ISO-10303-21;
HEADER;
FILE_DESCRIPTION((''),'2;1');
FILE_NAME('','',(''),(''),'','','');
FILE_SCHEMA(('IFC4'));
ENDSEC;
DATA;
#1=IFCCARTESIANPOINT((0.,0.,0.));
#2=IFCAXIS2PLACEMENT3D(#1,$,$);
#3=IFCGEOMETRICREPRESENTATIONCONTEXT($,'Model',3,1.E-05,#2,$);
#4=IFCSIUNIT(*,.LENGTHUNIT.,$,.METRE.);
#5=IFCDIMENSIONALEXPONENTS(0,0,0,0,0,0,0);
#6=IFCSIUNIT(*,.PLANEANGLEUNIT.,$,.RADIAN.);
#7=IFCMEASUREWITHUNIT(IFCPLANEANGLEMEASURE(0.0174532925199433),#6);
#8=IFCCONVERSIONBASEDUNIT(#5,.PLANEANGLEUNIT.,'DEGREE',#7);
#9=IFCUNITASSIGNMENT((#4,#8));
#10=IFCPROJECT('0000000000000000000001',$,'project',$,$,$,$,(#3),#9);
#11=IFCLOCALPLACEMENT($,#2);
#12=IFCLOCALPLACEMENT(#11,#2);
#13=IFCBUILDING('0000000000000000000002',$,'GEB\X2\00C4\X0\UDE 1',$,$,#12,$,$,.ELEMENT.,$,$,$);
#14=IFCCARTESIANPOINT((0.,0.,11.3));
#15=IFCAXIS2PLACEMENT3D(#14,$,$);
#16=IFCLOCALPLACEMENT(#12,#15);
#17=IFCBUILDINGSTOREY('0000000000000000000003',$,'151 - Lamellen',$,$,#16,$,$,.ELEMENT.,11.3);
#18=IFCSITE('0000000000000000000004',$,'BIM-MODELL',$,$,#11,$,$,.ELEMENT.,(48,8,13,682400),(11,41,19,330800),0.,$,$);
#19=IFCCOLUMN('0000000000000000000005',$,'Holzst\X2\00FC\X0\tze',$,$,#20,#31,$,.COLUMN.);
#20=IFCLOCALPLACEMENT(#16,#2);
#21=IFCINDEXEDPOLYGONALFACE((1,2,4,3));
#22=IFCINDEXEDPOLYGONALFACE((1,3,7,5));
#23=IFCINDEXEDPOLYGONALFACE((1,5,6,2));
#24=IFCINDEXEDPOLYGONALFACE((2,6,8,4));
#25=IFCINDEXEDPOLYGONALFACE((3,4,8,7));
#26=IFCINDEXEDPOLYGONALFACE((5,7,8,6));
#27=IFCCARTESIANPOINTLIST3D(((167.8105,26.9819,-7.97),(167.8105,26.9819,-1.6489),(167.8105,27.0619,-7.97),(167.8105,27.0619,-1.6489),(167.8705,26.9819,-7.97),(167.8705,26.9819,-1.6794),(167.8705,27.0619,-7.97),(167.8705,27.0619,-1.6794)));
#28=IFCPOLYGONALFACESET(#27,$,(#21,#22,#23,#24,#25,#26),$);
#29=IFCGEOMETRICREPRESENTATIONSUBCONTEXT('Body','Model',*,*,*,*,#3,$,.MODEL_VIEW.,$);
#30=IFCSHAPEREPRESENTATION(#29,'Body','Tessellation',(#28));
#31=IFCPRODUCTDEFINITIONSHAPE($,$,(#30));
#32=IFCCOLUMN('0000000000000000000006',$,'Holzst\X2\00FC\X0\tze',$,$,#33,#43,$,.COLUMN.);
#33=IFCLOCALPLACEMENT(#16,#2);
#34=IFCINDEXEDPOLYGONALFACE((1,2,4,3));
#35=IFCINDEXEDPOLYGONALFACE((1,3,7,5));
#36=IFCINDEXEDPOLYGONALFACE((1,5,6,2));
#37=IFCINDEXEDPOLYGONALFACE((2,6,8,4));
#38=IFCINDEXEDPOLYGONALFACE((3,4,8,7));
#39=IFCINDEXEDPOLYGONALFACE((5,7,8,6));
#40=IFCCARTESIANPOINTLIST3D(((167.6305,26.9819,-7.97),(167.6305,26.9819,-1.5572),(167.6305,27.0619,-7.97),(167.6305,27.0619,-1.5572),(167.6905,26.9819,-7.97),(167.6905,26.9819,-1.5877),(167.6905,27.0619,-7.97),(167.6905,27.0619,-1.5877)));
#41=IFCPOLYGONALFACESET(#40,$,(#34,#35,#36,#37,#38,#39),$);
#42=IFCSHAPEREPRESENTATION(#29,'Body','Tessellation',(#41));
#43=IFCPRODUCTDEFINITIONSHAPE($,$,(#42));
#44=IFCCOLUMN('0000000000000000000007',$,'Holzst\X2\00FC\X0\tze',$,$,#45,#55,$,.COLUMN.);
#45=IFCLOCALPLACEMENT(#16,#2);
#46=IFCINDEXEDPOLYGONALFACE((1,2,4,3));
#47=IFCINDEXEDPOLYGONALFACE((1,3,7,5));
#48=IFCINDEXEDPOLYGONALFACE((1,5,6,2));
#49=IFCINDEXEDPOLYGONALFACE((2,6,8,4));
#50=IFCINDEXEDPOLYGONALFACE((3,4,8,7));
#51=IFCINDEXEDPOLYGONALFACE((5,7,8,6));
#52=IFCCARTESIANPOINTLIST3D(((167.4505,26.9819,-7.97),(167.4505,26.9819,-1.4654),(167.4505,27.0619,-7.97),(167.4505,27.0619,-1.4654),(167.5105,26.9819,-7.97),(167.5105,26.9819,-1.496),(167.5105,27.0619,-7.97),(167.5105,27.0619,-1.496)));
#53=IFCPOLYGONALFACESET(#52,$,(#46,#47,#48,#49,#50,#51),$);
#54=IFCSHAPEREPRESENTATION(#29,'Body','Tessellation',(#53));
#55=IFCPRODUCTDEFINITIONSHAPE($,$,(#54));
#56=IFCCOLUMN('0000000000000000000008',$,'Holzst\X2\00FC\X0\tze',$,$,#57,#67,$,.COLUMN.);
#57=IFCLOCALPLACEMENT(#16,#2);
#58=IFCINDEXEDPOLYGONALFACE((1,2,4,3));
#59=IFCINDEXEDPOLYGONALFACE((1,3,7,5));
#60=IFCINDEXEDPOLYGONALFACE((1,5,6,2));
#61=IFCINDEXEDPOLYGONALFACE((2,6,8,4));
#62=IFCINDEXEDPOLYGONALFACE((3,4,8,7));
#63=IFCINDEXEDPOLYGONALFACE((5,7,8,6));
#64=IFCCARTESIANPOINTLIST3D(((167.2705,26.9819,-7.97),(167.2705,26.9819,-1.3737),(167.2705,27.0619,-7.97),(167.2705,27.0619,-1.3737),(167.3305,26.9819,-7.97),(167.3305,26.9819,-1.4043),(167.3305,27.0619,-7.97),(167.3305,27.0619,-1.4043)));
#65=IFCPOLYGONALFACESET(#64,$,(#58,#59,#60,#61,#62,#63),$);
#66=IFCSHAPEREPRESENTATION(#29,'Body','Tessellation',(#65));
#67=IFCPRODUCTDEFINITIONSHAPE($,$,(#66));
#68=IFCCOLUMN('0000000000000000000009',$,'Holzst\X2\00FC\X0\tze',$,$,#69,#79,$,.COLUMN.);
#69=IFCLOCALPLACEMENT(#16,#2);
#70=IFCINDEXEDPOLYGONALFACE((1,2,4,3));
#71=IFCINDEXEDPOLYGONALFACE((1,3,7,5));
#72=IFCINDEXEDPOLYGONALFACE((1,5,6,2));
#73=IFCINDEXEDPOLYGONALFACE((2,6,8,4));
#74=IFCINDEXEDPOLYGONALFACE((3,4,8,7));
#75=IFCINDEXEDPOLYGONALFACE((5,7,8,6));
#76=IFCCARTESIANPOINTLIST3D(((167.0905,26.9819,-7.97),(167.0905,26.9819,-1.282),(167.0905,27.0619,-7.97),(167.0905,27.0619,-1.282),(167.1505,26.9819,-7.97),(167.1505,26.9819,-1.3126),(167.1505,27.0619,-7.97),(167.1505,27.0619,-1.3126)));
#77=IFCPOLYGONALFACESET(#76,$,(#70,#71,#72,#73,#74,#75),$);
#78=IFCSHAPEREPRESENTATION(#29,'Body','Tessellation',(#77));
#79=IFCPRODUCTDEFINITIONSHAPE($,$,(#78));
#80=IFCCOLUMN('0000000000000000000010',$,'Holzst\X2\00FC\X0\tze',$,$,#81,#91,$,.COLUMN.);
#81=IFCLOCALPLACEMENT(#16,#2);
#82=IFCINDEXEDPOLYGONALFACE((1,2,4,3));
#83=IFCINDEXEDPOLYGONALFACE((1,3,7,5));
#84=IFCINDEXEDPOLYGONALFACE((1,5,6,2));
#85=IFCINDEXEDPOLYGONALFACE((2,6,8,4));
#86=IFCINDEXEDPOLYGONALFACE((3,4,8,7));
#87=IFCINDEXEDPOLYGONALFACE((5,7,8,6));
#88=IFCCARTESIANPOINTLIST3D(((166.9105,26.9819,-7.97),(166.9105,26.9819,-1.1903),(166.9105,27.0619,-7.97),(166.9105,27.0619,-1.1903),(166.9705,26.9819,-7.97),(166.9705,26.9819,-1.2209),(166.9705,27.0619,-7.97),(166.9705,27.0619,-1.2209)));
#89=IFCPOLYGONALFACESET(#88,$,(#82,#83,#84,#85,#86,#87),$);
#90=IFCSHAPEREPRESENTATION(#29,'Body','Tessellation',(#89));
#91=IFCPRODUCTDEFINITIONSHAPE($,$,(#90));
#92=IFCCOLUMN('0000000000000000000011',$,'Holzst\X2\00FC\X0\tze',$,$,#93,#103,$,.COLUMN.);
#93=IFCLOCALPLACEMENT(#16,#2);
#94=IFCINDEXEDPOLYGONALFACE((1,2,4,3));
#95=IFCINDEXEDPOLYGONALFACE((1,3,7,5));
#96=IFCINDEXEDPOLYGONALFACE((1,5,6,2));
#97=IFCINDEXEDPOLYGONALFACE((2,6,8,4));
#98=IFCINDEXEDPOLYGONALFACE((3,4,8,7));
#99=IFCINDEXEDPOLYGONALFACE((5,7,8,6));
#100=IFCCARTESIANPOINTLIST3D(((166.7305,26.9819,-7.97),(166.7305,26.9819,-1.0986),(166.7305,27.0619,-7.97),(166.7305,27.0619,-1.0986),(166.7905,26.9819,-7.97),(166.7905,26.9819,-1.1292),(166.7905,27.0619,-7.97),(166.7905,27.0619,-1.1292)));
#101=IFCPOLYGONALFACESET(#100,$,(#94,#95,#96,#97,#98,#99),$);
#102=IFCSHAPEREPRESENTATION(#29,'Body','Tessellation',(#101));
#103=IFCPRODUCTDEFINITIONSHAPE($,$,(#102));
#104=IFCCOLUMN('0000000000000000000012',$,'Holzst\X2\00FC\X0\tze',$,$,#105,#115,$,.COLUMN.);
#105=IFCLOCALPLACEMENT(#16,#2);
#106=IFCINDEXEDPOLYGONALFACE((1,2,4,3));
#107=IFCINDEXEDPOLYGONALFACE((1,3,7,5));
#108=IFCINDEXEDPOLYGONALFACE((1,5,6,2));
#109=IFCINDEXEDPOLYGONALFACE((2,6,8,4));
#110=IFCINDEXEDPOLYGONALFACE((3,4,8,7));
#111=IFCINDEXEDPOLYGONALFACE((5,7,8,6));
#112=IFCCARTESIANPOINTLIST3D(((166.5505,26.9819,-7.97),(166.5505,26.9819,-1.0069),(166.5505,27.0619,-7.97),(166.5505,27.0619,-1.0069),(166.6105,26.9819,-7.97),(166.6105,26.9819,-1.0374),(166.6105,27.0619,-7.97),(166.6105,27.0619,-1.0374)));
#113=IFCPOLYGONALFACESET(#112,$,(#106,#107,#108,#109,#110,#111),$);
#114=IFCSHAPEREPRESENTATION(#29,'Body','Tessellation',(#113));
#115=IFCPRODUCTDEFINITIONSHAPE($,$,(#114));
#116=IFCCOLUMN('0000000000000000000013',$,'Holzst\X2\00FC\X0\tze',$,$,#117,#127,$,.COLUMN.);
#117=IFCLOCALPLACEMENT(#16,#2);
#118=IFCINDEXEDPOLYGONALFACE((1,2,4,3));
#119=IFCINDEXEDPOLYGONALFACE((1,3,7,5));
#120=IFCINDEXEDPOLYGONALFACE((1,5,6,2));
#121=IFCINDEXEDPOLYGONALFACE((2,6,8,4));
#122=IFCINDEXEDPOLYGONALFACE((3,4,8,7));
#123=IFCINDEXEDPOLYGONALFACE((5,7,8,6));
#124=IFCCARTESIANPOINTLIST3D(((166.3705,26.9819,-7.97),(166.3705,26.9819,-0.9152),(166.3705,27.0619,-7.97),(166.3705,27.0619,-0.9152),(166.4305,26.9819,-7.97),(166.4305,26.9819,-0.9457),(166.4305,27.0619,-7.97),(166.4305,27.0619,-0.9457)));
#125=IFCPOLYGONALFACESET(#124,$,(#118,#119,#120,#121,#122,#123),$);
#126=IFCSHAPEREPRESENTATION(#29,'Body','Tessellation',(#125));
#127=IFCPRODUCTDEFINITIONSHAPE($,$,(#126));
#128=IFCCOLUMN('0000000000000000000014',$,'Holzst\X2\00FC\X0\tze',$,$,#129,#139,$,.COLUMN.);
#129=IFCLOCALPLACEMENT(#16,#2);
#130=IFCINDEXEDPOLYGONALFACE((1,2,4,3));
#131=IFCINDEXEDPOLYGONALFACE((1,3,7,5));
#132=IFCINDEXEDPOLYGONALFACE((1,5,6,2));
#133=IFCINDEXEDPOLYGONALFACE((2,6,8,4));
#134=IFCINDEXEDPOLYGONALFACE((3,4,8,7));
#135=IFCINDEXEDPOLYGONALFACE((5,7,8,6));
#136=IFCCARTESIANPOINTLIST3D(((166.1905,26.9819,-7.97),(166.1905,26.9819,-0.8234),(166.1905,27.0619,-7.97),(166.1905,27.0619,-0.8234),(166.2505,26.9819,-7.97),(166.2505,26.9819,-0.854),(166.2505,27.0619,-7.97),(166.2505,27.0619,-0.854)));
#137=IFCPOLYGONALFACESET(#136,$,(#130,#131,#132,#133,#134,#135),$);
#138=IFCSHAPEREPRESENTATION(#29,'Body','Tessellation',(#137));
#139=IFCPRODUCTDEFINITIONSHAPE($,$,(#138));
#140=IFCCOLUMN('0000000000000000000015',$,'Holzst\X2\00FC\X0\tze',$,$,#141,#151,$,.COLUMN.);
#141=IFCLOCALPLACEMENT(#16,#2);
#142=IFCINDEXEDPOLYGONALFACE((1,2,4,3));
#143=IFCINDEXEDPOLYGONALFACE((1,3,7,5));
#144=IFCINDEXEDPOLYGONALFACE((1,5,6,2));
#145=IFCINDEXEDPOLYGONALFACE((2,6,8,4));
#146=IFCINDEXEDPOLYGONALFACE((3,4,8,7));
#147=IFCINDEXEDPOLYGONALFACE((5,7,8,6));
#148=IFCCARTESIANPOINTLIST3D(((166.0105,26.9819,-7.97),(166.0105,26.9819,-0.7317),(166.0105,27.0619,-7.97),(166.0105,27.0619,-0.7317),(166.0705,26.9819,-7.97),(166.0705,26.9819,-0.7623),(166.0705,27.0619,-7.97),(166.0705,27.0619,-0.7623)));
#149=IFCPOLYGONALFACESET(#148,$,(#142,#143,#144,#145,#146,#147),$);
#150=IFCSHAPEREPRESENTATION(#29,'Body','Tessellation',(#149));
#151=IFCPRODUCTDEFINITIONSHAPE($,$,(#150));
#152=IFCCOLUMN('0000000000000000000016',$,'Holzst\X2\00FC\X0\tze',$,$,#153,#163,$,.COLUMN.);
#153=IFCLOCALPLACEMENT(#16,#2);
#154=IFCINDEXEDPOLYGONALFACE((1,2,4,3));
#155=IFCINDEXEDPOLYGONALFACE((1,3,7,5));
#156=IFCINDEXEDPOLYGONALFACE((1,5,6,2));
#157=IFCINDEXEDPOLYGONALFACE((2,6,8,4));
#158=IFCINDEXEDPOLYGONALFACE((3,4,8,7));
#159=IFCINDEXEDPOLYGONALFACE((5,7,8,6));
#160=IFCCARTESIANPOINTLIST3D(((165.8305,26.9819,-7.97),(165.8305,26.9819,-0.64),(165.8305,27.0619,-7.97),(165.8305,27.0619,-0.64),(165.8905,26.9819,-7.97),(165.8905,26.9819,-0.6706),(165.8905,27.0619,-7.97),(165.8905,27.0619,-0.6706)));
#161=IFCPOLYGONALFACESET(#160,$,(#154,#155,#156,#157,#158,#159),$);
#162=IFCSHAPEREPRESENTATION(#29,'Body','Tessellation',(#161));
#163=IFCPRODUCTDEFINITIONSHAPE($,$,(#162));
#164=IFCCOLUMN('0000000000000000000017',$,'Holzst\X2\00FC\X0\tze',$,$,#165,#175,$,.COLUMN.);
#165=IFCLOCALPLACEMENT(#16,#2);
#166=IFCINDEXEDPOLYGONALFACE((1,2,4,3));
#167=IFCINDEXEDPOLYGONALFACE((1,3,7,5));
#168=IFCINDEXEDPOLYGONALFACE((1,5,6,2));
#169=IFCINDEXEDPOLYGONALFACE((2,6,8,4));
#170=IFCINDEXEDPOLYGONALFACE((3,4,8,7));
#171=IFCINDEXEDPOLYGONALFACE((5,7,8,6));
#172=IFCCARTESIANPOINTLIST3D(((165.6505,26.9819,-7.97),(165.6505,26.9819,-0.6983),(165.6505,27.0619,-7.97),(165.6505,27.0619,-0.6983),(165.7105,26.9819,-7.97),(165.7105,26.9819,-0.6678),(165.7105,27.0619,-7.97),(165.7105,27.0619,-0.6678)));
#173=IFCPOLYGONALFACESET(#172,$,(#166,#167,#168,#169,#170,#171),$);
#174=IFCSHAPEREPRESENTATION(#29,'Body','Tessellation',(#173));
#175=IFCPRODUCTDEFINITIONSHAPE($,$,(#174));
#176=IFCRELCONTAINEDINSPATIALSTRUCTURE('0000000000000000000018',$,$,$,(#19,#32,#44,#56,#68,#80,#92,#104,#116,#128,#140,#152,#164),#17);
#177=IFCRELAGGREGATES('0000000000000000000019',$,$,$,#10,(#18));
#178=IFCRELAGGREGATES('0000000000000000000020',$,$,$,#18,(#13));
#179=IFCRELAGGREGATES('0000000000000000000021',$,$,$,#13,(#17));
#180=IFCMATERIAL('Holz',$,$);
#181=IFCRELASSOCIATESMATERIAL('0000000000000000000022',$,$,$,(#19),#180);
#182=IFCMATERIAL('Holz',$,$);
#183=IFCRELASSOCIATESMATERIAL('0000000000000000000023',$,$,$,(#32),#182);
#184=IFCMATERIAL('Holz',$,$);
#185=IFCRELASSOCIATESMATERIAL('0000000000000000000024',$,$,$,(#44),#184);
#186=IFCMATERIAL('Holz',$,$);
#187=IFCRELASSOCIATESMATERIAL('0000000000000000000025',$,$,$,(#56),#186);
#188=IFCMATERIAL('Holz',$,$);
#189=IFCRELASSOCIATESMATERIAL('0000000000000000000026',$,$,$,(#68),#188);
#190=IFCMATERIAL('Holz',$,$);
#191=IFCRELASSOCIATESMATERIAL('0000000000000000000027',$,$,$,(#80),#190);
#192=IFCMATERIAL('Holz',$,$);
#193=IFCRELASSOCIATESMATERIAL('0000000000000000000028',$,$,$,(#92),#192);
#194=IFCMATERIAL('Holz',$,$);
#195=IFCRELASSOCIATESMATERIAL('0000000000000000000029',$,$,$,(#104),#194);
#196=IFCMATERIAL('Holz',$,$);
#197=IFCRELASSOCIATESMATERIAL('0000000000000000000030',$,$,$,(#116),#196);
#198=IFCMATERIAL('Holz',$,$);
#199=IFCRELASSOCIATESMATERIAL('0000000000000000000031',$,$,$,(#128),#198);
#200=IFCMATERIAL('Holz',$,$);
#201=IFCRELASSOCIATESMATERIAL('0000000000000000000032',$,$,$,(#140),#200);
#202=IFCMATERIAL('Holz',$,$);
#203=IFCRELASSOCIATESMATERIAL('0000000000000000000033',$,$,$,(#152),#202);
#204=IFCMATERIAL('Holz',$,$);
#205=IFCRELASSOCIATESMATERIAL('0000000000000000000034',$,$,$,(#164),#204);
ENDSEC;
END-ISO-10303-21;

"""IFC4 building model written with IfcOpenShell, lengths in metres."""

from ifc_helpers import new_model, entity, si_unit, converted_unit, frame, frame_2d, origin, origin_with_axes, place, context, subcontext, project, spatial, rectangle, extrude, clip, halfspace, material, element, save


model = new_model("IFC4")

# Units and contexts
model_context = context("Model", 3, precision=1e-05, world=origin())
body_context = subcontext(model_context, "Body", "Model", "MODEL_VIEW")
ifc_project = project(units=[si_unit("LENGTHUNIT", "METRE"), converted_unit("PLANEANGLEUNIT", "DEGREE", entity("IfcPlaneAngleMeasure", 0.0174532925199433), si_unit("PLANEANGLEUNIT", "RADIAN"), dimensions=[0, 0, 0, 0, 0, 0, 0])], contexts=[model_context])

# Site, building, storey
site_placement = place(None, origin())
site = spatial("IfcSite", under=ifc_project, at=site_placement, Name="BIM-MODELL", CompositionType="ELEMENT", RefLatitude=(48, 8, 13, 682400), RefLongitude=(11, 41, 19, 330800), RefElevation=0.0)
building_placement = place(site_placement, origin())
building = spatial("IfcBuilding", under=site, at=building_placement, Name="GEBÄUDE 1", CompositionType="ELEMENT")
storey_placement = place(building_placement, frame((0.0, 0.0, 11.3)))
storey = spatial("IfcBuildingStorey", under=building, at=storey_placement, Name="151 - Lamellen", CompositionType="ELEMENT", Elevation=11.3)

# Columns
ifc_material_1 = material(Name="Holz")
column_1_placement = place(storey_placement, frame((167.8105, 26.9819, -7.97)))
element("IfcColumn", 1, at=column_1_placement, inside=storey, material=ifc_material_1, Name="Holzstütze", PredefinedType="COLUMN", context=body_context, shape_type="Clipping", body=[
    clip(extrude(rectangle(XDim=0.06, YDim=0.08, at=frame_2d((0.03, 0.04), x_axis=(1.0, 0.0))), origin_with_axes(), (0.0, 0.0, 1.0), 6.3211), halfspace(frame((0.03, 0.04, 6.3058), z_axis=(-0.45399, 0.0, -0.891007), x_axis=(0.0, -1.0, 0.0)), True)),
])
ifc_material_2 = material(Name="Holz")
column_2_placement = place(storey_placement, frame((167.6305, 26.9819, -7.97)))
element("IfcColumn", 2, at=column_2_placement, inside=storey, material=ifc_material_2, Name="Holzstütze", PredefinedType="COLUMN", context=body_context, shape_type="Clipping", body=[
    clip(extrude(rectangle(XDim=0.06, YDim=0.08, at=frame_2d((0.03, 0.04), x_axis=(1.0, 0.0))), origin_with_axes(), (0.0, 0.0, 1.0), 6.4128), halfspace(frame((0.03, 0.04, 6.3976), z_axis=(-0.45399, 0.0, -0.891007), x_axis=(0.0, -1.0, 0.0)), True)),
])
ifc_material_3 = material(Name="Holz")
column_3_placement = place(storey_placement, frame((167.4505, 26.9819, -7.97)))
element("IfcColumn", 3, at=column_3_placement, inside=storey, material=ifc_material_3, Name="Holzstütze", PredefinedType="COLUMN", context=body_context, shape_type="Clipping", body=[
    clip(extrude(rectangle(XDim=0.06, YDim=0.08, at=frame_2d((0.03, 0.04), x_axis=(1.0, 0.0))), origin_with_axes(), (0.0, 0.0, 1.0), 6.5046), halfspace(frame((0.03, 0.04, 6.4893), z_axis=(-0.45399, 0.0, -0.891007), x_axis=(0.0, -1.0, 0.0)), True)),
])
ifc_material_4 = material(Name="Holz")
column_4_placement = place(storey_placement, frame((167.2705, 26.9819, -7.97)))
element("IfcColumn", 4, at=column_4_placement, inside=storey, material=ifc_material_4, Name="Holzstütze", PredefinedType="COLUMN", context=body_context, shape_type="Clipping", body=[
    clip(extrude(rectangle(XDim=0.06, YDim=0.08, at=frame_2d((0.03, 0.04), x_axis=(1.0, 0.0))), origin_with_axes(), (0.0, 0.0, 1.0), 6.5963), halfspace(frame((0.03, 0.04, 6.581), z_axis=(-0.45399, 0.0, -0.891007), x_axis=(0.0, -1.0, 0.0)), True)),
])
ifc_material_5 = material(Name="Holz")
column_5_placement = place(storey_placement, frame((167.0905, 26.9819, -7.97)))
element("IfcColumn", 5, at=column_5_placement, inside=storey, material=ifc_material_5, Name="Holzstütze", PredefinedType="COLUMN", context=body_context, shape_type="Clipping", body=[
    clip(extrude(rectangle(XDim=0.06, YDim=0.08, at=frame_2d((0.03, 0.04), x_axis=(1.0, 0.0))), origin_with_axes(), (0.0, 0.0, 1.0), 6.688), halfspace(frame((0.03, 0.04, 6.6727), z_axis=(-0.45399, 0.0, -0.891007), x_axis=(0.0, -1.0, 0.0)), True)),
])
ifc_material_6 = material(Name="Holz")
column_6_placement = place(storey_placement, frame((166.9105, 26.9819, -7.97)))
element("IfcColumn", 6, at=column_6_placement, inside=storey, material=ifc_material_6, Name="Holzstütze", PredefinedType="COLUMN", context=body_context, shape_type="Clipping", body=[
    clip(extrude(rectangle(XDim=0.06, YDim=0.08, at=frame_2d((0.03, 0.04), x_axis=(1.0, 0.0))), origin_with_axes(), (0.0, 0.0, 1.0), 6.7797), halfspace(frame((0.03, 0.04, 6.7644), z_axis=(-0.45399, 0.0, -0.891007), x_axis=(0.0, -1.0, 0.0)), True)),
])
ifc_material_7 = material(Name="Holz")
column_7_placement = place(storey_placement, frame((166.7305, 26.9819, -7.97)))
element("IfcColumn", 7, at=column_7_placement, inside=storey, material=ifc_material_7, Name="Holzstütze", PredefinedType="COLUMN", context=body_context, shape_type="Clipping", body=[
    clip(extrude(rectangle(XDim=0.06, YDim=0.08, at=frame_2d((0.03, 0.04), x_axis=(1.0, 0.0))), origin_with_axes(), (0.0, 0.0, 1.0), 6.8714), halfspace(frame((0.03, 0.04, 6.8561), z_axis=(-0.45399, 0.0, -0.891007), x_axis=(0.0, -1.0, 0.0)), True)),
])
ifc_material_8 = material(Name="Holz")
column_8_placement = place(storey_placement, frame((166.5505, 26.9819, -7.97)))
element("IfcColumn", 8, at=column_8_placement, inside=storey, material=ifc_material_8, Name="Holzstütze", PredefinedType="COLUMN", context=body_context, shape_type="Clipping", body=[
    clip(extrude(rectangle(XDim=0.06, YDim=0.08, at=frame_2d((0.03, 0.04), x_axis=(1.0, 0.0))), origin_with_axes(), (0.0, 0.0, 1.0), 6.9631), halfspace(frame((0.03, 0.04, 6.9478), z_axis=(-0.45399, 0.0, -0.891007), x_axis=(0.0, -1.0, 0.0)), True)),
])
ifc_material_9 = material(Name="Holz")
column_9_placement = place(storey_placement, frame((166.3705, 26.9819, -7.97)))
element("IfcColumn", 9, at=column_9_placement, inside=storey, material=ifc_material_9, Name="Holzstütze", PredefinedType="COLUMN", context=body_context, shape_type="Clipping", body=[
    clip(extrude(rectangle(XDim=0.06, YDim=0.08, at=frame_2d((0.03, 0.04), x_axis=(1.0, 0.0))), origin_with_axes(), (0.0, 0.0, 1.0), 7.0548), halfspace(frame((0.03, 0.04, 7.0396), z_axis=(-0.45399, 0.0, -0.891007), x_axis=(0.0, -1.0, 0.0)), True)),
])
ifc_material_10 = material(Name="Holz")
column_10_placement = place(storey_placement, frame((166.1905, 26.9819, -7.97)))
element("IfcColumn", 10, at=column_10_placement, inside=storey, material=ifc_material_10, Name="Holzstütze", PredefinedType="COLUMN", context=body_context, shape_type="Clipping", body=[
    clip(extrude(rectangle(XDim=0.06, YDim=0.08, at=frame_2d((0.03, 0.04), x_axis=(1.0, 0.0))), origin_with_axes(), (0.0, 0.0, 1.0), 7.1466), halfspace(frame((0.03, 0.04, 7.1313), z_axis=(-0.45399, 0.0, -0.891007), x_axis=(0.0, -1.0, 0.0)), True)),
])
ifc_material_11 = material(Name="Holz")
column_11_placement = place(storey_placement, frame((166.0105, 26.9819, -7.97)))
element("IfcColumn", 11, at=column_11_placement, inside=storey, material=ifc_material_11, Name="Holzstütze", PredefinedType="COLUMN", context=body_context, shape_type="Clipping", body=[
    clip(extrude(rectangle(XDim=0.06, YDim=0.08, at=frame_2d((0.03, 0.04), x_axis=(1.0, 0.0))), origin_with_axes(), (0.0, 0.0, 1.0), 7.2383), halfspace(frame((0.03, 0.04, 7.223), z_axis=(-0.45399, 0.0, -0.891007), x_axis=(0.0, -1.0, 0.0)), True)),
])
ifc_material_12 = material(Name="Holz")
column_12_placement = place(storey_placement, frame((165.8305, 26.9819, -7.97)))
element("IfcColumn", 12, at=column_12_placement, inside=storey, material=ifc_material_12, Name="Holzstütze", PredefinedType="COLUMN", context=body_context, shape_type="Clipping", body=[
    clip(extrude(rectangle(XDim=0.06, YDim=0.08, at=frame_2d((0.03, 0.04), x_axis=(1.0, 0.0))), origin_with_axes(), (0.0, 0.0, 1.0), 7.33), halfspace(frame((0.03, 0.04, 7.3147), z_axis=(-0.45399, 0.0, -0.891007), x_axis=(0.0, -1.0, 0.0)), True)),
])
ifc_material_13 = material(Name="Holz")
column_13_placement = place(storey_placement, frame((165.6505, 26.9819, -7.97)))
element("IfcColumn", 13, at=column_13_placement, inside=storey, material=ifc_material_13, Name="Holzstütze", PredefinedType="COLUMN", context=body_context, shape_type="Clipping", body=[
    clip(extrude(rectangle(XDim=0.06, YDim=0.08, at=frame_2d((0.03, 0.04), x_axis=(1.0, 0.0))), origin_with_axes(), (0.0, 0.0, 1.0), 7.3022), halfspace(frame((0.03, 0.04, 7.2869), z_axis=(0.45399, 0.0, -0.891007), x_axis=(0.0, -1.0, 0.0)), True)),
])

save(model, "model.ifc")
